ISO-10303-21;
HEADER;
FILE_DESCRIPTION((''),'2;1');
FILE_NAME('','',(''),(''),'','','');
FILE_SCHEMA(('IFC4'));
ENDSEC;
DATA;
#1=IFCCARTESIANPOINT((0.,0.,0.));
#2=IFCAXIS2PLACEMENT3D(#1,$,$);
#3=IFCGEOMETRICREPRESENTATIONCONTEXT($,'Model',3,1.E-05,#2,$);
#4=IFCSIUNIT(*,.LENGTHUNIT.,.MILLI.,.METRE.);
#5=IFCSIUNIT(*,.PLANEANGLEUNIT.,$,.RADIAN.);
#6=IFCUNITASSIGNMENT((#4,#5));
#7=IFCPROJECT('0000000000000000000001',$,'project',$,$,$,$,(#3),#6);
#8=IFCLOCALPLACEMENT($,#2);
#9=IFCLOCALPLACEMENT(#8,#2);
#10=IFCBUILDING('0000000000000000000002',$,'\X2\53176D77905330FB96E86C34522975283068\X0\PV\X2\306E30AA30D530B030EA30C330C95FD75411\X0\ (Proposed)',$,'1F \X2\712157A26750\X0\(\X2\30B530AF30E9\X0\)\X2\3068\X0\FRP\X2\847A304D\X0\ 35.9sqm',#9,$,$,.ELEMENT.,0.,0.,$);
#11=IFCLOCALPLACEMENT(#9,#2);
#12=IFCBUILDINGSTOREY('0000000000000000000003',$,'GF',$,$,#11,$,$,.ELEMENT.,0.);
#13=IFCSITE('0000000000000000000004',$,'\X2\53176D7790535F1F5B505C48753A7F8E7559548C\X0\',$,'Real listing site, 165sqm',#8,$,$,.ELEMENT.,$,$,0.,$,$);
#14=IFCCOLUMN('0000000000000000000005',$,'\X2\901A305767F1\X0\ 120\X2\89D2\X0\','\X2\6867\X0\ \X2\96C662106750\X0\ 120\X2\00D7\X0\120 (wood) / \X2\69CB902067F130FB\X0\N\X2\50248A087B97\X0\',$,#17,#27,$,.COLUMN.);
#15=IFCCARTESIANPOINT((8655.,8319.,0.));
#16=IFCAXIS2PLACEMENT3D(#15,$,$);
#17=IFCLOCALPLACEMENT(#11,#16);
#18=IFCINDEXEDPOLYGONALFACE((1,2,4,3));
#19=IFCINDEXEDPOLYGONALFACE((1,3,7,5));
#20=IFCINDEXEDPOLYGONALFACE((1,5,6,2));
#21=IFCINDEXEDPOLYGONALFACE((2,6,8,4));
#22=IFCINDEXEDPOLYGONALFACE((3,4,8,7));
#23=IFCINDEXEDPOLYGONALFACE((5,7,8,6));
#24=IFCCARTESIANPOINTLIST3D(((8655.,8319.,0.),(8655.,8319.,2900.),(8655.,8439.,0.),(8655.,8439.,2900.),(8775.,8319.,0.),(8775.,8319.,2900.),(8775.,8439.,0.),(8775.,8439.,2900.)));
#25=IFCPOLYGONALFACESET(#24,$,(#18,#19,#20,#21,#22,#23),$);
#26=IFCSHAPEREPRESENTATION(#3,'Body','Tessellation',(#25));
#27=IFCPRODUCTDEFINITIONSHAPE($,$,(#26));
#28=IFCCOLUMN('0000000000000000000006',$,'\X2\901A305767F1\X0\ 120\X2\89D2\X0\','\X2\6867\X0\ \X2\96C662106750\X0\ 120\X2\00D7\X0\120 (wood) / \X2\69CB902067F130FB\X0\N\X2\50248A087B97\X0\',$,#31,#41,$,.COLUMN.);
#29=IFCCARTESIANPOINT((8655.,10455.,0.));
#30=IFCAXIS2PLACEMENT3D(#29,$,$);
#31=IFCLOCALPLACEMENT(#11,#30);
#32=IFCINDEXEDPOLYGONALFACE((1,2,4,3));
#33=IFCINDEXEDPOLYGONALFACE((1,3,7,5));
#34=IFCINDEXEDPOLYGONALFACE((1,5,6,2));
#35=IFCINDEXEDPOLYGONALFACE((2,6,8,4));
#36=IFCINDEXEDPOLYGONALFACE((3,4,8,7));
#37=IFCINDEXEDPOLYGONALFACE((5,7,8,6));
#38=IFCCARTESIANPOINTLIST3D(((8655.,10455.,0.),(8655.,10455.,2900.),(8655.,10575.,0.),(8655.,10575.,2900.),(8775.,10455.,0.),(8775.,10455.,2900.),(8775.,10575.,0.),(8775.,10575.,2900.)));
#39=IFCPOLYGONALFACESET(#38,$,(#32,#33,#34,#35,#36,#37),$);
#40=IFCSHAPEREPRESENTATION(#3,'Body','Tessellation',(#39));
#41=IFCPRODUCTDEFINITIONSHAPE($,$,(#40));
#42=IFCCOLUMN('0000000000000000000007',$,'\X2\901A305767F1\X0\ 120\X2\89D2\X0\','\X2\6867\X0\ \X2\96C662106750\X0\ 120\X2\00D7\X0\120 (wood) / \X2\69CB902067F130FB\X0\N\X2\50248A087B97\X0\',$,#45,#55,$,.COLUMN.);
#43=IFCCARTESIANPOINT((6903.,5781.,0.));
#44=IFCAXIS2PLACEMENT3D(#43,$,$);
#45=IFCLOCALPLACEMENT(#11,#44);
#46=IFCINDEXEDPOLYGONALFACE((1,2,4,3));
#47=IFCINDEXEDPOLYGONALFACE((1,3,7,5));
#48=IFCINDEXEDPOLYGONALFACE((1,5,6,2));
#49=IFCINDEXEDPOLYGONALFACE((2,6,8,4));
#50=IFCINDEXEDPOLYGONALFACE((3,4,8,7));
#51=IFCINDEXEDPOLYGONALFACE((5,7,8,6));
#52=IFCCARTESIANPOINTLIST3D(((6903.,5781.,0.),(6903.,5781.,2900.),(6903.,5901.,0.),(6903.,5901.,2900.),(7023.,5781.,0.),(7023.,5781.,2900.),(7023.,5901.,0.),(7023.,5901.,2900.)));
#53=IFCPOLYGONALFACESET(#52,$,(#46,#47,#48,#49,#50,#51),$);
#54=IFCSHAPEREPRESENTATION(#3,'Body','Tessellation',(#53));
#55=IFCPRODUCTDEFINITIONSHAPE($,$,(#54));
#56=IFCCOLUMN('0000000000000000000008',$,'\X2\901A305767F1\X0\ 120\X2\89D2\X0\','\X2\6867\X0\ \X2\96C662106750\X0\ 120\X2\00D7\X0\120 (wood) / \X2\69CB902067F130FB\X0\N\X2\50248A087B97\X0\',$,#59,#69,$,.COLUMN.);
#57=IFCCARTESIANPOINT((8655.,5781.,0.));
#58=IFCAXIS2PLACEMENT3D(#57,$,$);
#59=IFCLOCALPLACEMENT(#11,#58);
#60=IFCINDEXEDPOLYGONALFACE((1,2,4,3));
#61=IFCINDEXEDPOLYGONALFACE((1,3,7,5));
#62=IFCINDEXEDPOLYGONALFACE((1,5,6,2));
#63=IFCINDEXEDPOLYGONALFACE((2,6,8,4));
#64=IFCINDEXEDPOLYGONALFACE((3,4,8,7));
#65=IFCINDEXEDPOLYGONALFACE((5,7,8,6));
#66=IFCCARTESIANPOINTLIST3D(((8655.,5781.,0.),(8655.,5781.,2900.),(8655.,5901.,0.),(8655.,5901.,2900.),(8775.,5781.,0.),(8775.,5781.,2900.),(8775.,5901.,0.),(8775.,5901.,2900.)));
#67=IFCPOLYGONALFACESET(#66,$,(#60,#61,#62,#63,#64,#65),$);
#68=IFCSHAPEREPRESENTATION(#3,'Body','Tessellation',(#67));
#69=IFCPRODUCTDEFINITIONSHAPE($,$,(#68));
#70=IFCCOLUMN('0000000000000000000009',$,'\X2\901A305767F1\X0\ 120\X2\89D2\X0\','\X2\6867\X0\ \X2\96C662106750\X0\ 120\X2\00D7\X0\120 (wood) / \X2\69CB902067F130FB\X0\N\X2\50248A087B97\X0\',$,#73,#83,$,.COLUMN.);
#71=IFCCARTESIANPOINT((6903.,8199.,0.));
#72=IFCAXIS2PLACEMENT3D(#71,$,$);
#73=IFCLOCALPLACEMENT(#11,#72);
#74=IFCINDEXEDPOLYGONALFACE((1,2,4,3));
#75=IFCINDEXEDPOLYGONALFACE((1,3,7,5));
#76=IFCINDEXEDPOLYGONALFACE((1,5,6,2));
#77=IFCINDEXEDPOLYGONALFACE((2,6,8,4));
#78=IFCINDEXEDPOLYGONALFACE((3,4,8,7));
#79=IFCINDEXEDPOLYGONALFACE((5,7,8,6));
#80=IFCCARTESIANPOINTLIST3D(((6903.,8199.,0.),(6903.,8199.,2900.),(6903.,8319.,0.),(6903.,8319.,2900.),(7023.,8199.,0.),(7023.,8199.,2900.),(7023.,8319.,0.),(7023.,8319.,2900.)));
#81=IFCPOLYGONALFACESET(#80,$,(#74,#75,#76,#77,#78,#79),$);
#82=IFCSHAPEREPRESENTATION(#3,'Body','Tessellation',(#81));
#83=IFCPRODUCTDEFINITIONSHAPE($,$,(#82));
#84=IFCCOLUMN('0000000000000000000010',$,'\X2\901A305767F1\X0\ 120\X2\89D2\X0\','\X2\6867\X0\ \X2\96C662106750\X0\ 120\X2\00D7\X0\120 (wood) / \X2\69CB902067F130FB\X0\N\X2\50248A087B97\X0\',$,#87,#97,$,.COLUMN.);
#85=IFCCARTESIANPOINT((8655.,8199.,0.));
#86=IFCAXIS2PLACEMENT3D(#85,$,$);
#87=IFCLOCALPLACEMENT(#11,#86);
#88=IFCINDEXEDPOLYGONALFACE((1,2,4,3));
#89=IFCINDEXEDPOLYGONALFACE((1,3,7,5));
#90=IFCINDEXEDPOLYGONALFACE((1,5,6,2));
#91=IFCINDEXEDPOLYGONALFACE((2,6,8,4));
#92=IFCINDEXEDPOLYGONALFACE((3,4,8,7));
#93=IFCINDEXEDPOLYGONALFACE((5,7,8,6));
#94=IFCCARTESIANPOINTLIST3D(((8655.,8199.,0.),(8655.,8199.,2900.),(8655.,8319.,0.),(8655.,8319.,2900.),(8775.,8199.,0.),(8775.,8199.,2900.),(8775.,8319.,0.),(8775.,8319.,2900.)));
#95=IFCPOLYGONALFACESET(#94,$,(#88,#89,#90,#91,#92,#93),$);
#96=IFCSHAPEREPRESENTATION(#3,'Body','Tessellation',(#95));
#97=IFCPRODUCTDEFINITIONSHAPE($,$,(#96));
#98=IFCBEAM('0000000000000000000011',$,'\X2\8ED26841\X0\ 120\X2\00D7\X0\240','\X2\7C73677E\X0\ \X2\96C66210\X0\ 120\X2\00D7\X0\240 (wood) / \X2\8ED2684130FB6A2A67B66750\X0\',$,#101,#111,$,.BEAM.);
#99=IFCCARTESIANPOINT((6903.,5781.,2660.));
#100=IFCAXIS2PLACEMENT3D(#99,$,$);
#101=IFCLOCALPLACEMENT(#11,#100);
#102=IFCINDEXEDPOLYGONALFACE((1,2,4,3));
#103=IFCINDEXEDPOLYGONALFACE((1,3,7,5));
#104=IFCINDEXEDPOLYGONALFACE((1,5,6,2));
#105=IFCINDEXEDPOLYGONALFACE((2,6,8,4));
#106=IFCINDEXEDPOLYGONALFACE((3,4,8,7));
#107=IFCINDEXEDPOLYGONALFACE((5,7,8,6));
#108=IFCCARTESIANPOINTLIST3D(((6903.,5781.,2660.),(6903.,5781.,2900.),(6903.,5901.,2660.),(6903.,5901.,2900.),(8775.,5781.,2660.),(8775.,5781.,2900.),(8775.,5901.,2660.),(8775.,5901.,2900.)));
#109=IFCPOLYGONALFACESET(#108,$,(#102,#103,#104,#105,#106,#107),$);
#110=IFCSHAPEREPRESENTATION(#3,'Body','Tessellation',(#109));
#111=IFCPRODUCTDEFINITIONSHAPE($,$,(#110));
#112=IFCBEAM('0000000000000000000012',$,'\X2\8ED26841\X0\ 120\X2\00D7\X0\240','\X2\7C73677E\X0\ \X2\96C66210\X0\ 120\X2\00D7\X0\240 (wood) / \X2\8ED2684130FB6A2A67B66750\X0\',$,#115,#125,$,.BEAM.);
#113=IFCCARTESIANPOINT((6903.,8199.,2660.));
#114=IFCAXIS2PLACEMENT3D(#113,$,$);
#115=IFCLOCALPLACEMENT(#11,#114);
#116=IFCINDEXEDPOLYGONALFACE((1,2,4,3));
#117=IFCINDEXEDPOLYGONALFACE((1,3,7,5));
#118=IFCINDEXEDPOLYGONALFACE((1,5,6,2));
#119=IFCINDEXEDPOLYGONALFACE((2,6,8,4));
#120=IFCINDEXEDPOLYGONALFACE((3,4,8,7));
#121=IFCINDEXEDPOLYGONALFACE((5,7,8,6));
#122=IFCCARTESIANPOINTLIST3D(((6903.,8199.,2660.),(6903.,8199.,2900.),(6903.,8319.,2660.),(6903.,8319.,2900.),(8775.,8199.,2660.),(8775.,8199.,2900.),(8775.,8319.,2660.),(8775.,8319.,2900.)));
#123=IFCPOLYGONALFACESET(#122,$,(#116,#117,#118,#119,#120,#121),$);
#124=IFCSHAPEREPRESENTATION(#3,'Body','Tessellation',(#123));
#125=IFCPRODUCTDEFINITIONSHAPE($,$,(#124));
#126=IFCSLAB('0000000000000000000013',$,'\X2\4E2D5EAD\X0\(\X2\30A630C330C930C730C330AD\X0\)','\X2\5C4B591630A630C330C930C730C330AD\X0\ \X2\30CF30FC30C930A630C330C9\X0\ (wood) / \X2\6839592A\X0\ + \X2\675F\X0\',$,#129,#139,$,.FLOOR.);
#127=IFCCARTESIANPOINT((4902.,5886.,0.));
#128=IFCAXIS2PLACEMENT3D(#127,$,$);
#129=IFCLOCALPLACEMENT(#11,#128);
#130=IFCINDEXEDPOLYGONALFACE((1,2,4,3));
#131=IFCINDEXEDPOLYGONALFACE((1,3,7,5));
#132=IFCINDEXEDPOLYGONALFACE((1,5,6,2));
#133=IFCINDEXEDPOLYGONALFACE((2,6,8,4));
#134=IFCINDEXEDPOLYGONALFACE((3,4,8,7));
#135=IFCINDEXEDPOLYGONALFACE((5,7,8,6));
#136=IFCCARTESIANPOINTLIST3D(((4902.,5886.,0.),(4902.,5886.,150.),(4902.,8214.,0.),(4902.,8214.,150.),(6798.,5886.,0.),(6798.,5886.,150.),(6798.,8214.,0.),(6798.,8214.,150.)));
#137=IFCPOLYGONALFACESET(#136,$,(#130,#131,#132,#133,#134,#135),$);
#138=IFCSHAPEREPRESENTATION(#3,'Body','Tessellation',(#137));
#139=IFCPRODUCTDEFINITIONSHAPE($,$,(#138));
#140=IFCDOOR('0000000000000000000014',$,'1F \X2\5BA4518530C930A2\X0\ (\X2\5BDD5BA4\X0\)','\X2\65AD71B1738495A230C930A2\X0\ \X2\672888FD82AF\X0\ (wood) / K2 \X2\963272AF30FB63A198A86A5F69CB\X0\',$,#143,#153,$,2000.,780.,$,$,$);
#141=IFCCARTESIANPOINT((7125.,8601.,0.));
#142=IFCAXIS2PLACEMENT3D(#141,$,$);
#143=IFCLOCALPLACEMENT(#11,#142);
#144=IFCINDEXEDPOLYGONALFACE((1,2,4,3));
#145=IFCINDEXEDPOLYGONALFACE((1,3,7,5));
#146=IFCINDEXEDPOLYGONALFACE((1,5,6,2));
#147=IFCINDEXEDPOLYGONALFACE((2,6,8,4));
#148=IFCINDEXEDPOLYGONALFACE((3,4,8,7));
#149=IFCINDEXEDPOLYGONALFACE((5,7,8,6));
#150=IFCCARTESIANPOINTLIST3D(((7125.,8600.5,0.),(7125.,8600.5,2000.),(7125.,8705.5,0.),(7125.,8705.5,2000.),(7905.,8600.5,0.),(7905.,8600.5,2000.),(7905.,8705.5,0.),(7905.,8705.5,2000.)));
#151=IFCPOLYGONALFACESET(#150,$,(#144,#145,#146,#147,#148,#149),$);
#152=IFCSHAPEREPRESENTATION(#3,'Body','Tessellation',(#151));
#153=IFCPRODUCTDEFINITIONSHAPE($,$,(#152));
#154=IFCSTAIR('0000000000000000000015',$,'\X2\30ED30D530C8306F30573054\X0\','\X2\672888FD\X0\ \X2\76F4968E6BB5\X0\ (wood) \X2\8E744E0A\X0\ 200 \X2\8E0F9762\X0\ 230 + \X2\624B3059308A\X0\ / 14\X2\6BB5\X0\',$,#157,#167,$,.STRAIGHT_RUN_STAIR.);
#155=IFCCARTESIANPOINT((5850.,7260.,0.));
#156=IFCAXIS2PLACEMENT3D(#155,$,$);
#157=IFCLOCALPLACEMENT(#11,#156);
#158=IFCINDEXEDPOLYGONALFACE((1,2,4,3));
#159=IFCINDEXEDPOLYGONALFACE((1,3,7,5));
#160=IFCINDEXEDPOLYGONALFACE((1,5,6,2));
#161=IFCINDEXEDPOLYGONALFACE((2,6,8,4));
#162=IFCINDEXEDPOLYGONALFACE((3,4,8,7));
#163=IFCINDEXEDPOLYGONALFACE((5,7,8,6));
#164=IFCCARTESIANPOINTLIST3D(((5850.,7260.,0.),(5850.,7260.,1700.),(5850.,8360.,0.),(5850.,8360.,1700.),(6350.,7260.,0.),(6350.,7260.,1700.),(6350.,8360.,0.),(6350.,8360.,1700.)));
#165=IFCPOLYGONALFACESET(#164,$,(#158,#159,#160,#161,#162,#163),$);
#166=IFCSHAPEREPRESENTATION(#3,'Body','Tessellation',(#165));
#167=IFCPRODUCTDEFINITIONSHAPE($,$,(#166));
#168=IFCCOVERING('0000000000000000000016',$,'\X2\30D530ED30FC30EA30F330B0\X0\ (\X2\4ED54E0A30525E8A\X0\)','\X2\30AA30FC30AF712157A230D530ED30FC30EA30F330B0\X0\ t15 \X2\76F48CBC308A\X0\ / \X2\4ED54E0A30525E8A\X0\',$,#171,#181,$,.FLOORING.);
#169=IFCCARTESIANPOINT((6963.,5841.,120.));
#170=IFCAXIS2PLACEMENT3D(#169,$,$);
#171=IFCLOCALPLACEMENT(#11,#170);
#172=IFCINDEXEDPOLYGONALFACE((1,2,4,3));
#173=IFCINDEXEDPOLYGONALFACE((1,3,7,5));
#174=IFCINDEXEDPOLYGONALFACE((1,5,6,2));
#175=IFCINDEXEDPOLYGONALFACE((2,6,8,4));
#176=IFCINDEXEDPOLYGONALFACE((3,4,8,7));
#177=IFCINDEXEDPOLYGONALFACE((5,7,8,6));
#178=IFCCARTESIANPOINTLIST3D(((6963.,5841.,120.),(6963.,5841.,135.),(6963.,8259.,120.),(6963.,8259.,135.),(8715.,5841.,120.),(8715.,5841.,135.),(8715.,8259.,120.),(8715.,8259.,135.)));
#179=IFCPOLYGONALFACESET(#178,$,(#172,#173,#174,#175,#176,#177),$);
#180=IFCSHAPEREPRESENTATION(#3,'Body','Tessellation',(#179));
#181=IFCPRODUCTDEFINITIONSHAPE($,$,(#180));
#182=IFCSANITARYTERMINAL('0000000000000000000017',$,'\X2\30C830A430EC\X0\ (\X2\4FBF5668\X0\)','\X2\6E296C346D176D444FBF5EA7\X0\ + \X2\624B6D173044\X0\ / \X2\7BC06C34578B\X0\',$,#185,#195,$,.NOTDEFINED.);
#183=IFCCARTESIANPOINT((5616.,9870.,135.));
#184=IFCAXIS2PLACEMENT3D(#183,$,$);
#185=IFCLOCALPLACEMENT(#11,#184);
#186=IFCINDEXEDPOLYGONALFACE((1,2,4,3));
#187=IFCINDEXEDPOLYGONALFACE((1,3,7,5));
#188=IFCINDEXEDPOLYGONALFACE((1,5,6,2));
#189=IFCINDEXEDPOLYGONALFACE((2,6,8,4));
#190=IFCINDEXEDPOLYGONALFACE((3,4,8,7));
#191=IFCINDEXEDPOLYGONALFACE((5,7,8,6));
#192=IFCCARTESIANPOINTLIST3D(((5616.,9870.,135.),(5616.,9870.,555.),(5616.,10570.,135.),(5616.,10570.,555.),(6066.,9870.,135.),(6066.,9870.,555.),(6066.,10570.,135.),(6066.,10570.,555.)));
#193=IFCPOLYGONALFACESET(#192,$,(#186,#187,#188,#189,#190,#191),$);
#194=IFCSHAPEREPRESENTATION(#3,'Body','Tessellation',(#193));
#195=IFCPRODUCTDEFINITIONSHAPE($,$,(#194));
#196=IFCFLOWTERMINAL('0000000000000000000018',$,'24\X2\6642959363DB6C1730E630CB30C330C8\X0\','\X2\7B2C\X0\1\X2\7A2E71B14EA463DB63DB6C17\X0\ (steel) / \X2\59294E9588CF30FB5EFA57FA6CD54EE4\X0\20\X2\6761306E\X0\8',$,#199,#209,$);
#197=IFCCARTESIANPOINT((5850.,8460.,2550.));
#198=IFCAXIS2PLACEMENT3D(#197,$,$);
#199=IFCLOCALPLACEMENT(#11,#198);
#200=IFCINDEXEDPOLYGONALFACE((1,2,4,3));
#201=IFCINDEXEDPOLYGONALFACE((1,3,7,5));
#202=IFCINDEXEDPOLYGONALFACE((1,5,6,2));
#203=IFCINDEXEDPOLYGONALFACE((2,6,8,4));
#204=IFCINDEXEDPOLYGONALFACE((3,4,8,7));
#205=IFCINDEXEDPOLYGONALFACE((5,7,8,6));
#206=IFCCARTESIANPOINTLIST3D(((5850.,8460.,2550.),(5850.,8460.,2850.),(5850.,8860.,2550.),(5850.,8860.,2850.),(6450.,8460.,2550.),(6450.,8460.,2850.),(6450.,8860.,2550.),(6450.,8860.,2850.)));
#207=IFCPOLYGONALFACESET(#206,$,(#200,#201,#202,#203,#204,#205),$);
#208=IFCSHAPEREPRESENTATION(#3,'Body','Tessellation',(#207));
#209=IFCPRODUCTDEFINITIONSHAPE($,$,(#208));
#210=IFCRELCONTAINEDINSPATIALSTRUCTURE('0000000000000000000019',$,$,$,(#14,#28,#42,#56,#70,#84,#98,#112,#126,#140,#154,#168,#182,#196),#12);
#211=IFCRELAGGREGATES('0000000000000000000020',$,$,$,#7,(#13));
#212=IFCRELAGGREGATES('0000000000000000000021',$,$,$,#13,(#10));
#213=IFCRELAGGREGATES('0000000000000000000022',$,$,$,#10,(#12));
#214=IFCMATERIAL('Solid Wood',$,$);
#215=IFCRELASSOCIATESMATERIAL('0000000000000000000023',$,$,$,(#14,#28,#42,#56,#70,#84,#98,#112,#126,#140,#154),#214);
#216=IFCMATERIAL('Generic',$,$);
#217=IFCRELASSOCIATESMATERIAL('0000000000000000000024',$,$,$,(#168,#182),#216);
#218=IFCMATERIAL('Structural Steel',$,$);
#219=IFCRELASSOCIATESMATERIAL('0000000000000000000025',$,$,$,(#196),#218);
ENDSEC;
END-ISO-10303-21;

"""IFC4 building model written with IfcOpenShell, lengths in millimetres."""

from ifc_helpers import new_model, si_unit, frame, frame_2d, origin, place, context, project, spatial, rectangle, extrude, material, element, save


model = new_model("IFC4")

# Units and contexts
model_context = context("Model", 3, precision=1e-05, world=origin())
ifc_project = project(units=[si_unit("LENGTHUNIT", "METRE", prefix="MILLI"), si_unit("PLANEANGLEUNIT", "RADIAN")], contexts=[model_context])

# Site, building, storey
site_placement = place(None, origin())
site = spatial("IfcSite", under=ifc_project, at=site_placement, Name="北海道弟子屈町美留和", ObjectType="Real listing site, 165sqm", CompositionType="ELEMENT", RefElevation=0.0)
building_placement = place(site_placement, origin())
building = spatial("IfcBuilding", under=site, at=building_placement, Name="北海道・雨水利用とPVのオフグリッド志向 (Proposed)", ObjectType="1F 無垢材(サクラ)とFRP葺き 35.9sqm", CompositionType="ELEMENT", ElevationOfRefHeight=0.0, ElevationOfTerrain=0.0)
storey_placement = place(building_placement, origin())
storey = spatial("IfcBuildingStorey", under=building, at=storey_placement, Name="GF", CompositionType="ELEMENT", Elevation=0.0)

# Columns
ifc_material_1 = material(Name="Solid Wood")
column_1_placement = place(storey_placement, frame((8655.0, 8319.0, 0.0)))
element("IfcColumn", 1, at=column_1_placement, inside=storey, material=ifc_material_1, Name="通し柱 120角", Description="桧 集成材 120×120 (wood) / 構造柱・N値計算", PredefinedType="COLUMN", context=model_context, shape_type="SweptSolid", body=[
    extrude(rectangle(XDim=120.0, YDim=120.0, at=frame_2d((60.0, 60.0))), frame((8655.0, 8319.0, 0.0)), (0.0, 0.0, 1.0), 2900.0),
])
column_2_placement = place(storey_placement, frame((8655.0, 10455.0, 0.0)))
element("IfcColumn", 2, at=column_2_placement, inside=storey, material=ifc_material_1, Name="通し柱 120角", Description="桧 集成材 120×120 (wood) / 構造柱・N値計算", PredefinedType="COLUMN", context=model_context, shape_type="SweptSolid", body=[
    extrude(rectangle(XDim=120.0, YDim=120.0, at=frame_2d((60.0, 60.0))), frame((8655.0, 10455.0, 0.0)), (0.0, 0.0, 1.0), 2900.0),
])
column_3_placement = place(storey_placement, frame((6903.0, 5781.0, 0.0)))
element("IfcColumn", 3, at=column_3_placement, inside=storey, material=ifc_material_1, Name="通し柱 120角", Description="桧 集成材 120×120 (wood) / 構造柱・N値計算", PredefinedType="COLUMN", context=model_context, shape_type="SweptSolid", body=[
    extrude(rectangle(XDim=120.0, YDim=120.0, at=frame_2d((60.0, 60.0))), frame((6903.0, 5781.0, 0.0)), (0.0, 0.0, 1.0), 2900.0),
])
column_4_placement = place(storey_placement, frame((8655.0, 5781.0, 0.0)))
element("IfcColumn", 4, at=column_4_placement, inside=storey, material=ifc_material_1, Name="通し柱 120角", Description="桧 集成材 120×120 (wood) / 構造柱・N値計算", PredefinedType="COLUMN", context=model_context, shape_type="SweptSolid", body=[
    extrude(rectangle(XDim=120.0, YDim=120.0, at=frame_2d((60.0, 60.0))), frame((8655.0, 5781.0, 0.0)), (0.0, 0.0, 1.0), 2900.0),
])
column_5_placement = place(storey_placement, frame((6903.0, 8199.0, 0.0)))
element("IfcColumn", 5, at=column_5_placement, inside=storey, material=ifc_material_1, Name="通し柱 120角", Description="桧 集成材 120×120 (wood) / 構造柱・N値計算", PredefinedType="COLUMN", context=model_context, shape_type="SweptSolid", body=[
    extrude(rectangle(XDim=120.0, YDim=120.0, at=frame_2d((60.0, 60.0))), frame((6903.0, 8199.0, 0.0)), (0.0, 0.0, 1.0), 2900.0),
])
column_6_placement = place(storey_placement, frame((8655.0, 8199.0, 0.0)))
element("IfcColumn", 6, at=column_6_placement, inside=storey, material=ifc_material_1, Name="通し柱 120角", Description="桧 集成材 120×120 (wood) / 構造柱・N値計算", PredefinedType="COLUMN", context=model_context, shape_type="SweptSolid", body=[
    extrude(rectangle(XDim=120.0, YDim=120.0, at=frame_2d((60.0, 60.0))), frame((8655.0, 8199.0, 0.0)), (0.0, 0.0, 1.0), 2900.0),
])

# Beams
beam_1_placement = place(storey_placement, frame((6903.0, 5781.0, 2660.0)))
element("IfcBeam", 7, at=beam_1_placement, inside=storey, material=ifc_material_1, Name="軒桁 120×240", Description="米松 集成 120×240 (wood) / 軒桁・横架材", PredefinedType="BEAM", context=model_context, shape_type="SweptSolid", body=[
    extrude(rectangle(XDim=1872.0, YDim=120.0, at=frame_2d((936.0, 60.0))), frame((6903.0, 5781.0, 2660.0)), (0.0, 0.0, 1.0), 240.0),
])
beam_2_placement = place(storey_placement, frame((6903.0, 8199.0, 2660.0)))
element("IfcBeam", 8, at=beam_2_placement, inside=storey, material=ifc_material_1, Name="軒桁 120×240", Description="米松 集成 120×240 (wood) / 軒桁・横架材", PredefinedType="BEAM", context=model_context, shape_type="SweptSolid", body=[
    extrude(rectangle(XDim=1872.0, YDim=120.0, at=frame_2d((936.0, 60.0))), frame((6903.0, 8199.0, 2660.0)), (0.0, 0.0, 1.0), 240.0),
])

# Slab
slab_placement = place(storey_placement, frame((4902.0, 5886.0, 0.0)))
element("IfcSlab", 9, at=slab_placement, inside=storey, material=ifc_material_1, Name="中庭(ウッドデッキ)", Description="屋外ウッドデッキ ハードウッド (wood) / 根太 + 束", PredefinedType="FLOOR", context=model_context, shape_type="SweptSolid", body=[
    extrude(rectangle(XDim=1896.0, YDim=2328.0, at=frame_2d((948.0, 1164.0))), frame((4902.0, 5886.0, 0.0)), (0.0, 0.0, 1.0), 150.0),
])

# Door
door_placement = place(storey_placement, frame((7125.0, 8601.0, 0.0)))
element("IfcDoor", 10, at=door_placement, inside=storey, material=ifc_material_1, Name="1F 室内ドア (寝室)", Description="断熱玄関ドア 木製芯 (wood) / K2 防犯・採風機構", OverallHeight=2000.0, OverallWidth=780.0, context=model_context, shape_type="SweptSolid", body=[
    extrude(rectangle(XDim=780.0, YDim=105.0, at=frame_2d((390.0, 52.0))), frame((7125.0, 8601.0, 0.0)), (0.0, 0.0, 1.0), 2000.0),
])

# Stair
stair_placement = place(storey_placement, frame((5850.0, 7260.0, 0.0)))
element("IfcStair", 11, at=stair_placement, inside=storey, material=ifc_material_1, Name="ロフトはしご", Description="木製 直階段 (wood) 蹴上 200 踏面 230 + 手すり / 14段", PredefinedType="STRAIGHT_RUN_STAIR", context=model_context, shape_type="SweptSolid", body=[
    extrude(rectangle(XDim=500.0, YDim=1100.0, at=frame_2d((250.0, 550.0))), frame((5850.0, 7260.0, 0.0)), (0.0, 0.0, 1.0), 1700.0),
])

# Covering
ifc_material_2 = material(Name="Generic")
covering_placement = place(storey_placement, frame((6963.0, 5841.0, 120.0)))
element("IfcCovering", 12, at=covering_placement, inside=storey, material=ifc_material_2, Name="フローリング (仕上げ床)", Description="オーク無垢フローリング t15 直貼り / 仕上げ床", PredefinedType="FLOORING", context=model_context, shape_type="SweptSolid", body=[
    extrude(rectangle(XDim=1752.0, YDim=2418.0, at=frame_2d((876.0, 1209.0))), frame((6963.0, 5841.0, 120.0)), (0.0, 0.0, 1.0), 15.0),
])

# Sanitary terminal
sanitary_terminal_placement = place(storey_placement, frame((5616.0, 9870.0, 135.0)))
element("IfcSanitaryTerminal", 13, at=sanitary_terminal_placement, inside=storey, material=ifc_material_2, Name="トイレ (便器)", Description="温水洗浄便座 + 手洗い / 節水型", PredefinedType="NOTDEFINED", context=model_context, shape_type="SweptSolid", body=[
    extrude(rectangle(XDim=450.0, YDim=700.0, at=frame_2d((225.0, 350.0))), frame((5616.0, 9870.0, 135.0)), (0.0, 0.0, 1.0), 420.0),
])

# Flow terminal
ifc_material_3 = material(Name="Structural Steel")
flow_terminal_placement = place(storey_placement, frame((5850.0, 8460.0, 2550.0)))
element("IfcFlowTerminal", 14, at=flow_terminal_placement, inside=storey, material=ifc_material_3, Name="24時間換気ユニット", Description="第1種熱交換換気 (steel) / 天井裏・建基法令20条の8", context=model_context, shape_type="SweptSolid", body=[
    extrude(rectangle(XDim=600.0, YDim=400.0, at=frame_2d((300.0, 200.0))), frame((5850.0, 8460.0, 2550.0)), (0.0, 0.0, 1.0), 300.0),
])

save(model, "model.ifc")
